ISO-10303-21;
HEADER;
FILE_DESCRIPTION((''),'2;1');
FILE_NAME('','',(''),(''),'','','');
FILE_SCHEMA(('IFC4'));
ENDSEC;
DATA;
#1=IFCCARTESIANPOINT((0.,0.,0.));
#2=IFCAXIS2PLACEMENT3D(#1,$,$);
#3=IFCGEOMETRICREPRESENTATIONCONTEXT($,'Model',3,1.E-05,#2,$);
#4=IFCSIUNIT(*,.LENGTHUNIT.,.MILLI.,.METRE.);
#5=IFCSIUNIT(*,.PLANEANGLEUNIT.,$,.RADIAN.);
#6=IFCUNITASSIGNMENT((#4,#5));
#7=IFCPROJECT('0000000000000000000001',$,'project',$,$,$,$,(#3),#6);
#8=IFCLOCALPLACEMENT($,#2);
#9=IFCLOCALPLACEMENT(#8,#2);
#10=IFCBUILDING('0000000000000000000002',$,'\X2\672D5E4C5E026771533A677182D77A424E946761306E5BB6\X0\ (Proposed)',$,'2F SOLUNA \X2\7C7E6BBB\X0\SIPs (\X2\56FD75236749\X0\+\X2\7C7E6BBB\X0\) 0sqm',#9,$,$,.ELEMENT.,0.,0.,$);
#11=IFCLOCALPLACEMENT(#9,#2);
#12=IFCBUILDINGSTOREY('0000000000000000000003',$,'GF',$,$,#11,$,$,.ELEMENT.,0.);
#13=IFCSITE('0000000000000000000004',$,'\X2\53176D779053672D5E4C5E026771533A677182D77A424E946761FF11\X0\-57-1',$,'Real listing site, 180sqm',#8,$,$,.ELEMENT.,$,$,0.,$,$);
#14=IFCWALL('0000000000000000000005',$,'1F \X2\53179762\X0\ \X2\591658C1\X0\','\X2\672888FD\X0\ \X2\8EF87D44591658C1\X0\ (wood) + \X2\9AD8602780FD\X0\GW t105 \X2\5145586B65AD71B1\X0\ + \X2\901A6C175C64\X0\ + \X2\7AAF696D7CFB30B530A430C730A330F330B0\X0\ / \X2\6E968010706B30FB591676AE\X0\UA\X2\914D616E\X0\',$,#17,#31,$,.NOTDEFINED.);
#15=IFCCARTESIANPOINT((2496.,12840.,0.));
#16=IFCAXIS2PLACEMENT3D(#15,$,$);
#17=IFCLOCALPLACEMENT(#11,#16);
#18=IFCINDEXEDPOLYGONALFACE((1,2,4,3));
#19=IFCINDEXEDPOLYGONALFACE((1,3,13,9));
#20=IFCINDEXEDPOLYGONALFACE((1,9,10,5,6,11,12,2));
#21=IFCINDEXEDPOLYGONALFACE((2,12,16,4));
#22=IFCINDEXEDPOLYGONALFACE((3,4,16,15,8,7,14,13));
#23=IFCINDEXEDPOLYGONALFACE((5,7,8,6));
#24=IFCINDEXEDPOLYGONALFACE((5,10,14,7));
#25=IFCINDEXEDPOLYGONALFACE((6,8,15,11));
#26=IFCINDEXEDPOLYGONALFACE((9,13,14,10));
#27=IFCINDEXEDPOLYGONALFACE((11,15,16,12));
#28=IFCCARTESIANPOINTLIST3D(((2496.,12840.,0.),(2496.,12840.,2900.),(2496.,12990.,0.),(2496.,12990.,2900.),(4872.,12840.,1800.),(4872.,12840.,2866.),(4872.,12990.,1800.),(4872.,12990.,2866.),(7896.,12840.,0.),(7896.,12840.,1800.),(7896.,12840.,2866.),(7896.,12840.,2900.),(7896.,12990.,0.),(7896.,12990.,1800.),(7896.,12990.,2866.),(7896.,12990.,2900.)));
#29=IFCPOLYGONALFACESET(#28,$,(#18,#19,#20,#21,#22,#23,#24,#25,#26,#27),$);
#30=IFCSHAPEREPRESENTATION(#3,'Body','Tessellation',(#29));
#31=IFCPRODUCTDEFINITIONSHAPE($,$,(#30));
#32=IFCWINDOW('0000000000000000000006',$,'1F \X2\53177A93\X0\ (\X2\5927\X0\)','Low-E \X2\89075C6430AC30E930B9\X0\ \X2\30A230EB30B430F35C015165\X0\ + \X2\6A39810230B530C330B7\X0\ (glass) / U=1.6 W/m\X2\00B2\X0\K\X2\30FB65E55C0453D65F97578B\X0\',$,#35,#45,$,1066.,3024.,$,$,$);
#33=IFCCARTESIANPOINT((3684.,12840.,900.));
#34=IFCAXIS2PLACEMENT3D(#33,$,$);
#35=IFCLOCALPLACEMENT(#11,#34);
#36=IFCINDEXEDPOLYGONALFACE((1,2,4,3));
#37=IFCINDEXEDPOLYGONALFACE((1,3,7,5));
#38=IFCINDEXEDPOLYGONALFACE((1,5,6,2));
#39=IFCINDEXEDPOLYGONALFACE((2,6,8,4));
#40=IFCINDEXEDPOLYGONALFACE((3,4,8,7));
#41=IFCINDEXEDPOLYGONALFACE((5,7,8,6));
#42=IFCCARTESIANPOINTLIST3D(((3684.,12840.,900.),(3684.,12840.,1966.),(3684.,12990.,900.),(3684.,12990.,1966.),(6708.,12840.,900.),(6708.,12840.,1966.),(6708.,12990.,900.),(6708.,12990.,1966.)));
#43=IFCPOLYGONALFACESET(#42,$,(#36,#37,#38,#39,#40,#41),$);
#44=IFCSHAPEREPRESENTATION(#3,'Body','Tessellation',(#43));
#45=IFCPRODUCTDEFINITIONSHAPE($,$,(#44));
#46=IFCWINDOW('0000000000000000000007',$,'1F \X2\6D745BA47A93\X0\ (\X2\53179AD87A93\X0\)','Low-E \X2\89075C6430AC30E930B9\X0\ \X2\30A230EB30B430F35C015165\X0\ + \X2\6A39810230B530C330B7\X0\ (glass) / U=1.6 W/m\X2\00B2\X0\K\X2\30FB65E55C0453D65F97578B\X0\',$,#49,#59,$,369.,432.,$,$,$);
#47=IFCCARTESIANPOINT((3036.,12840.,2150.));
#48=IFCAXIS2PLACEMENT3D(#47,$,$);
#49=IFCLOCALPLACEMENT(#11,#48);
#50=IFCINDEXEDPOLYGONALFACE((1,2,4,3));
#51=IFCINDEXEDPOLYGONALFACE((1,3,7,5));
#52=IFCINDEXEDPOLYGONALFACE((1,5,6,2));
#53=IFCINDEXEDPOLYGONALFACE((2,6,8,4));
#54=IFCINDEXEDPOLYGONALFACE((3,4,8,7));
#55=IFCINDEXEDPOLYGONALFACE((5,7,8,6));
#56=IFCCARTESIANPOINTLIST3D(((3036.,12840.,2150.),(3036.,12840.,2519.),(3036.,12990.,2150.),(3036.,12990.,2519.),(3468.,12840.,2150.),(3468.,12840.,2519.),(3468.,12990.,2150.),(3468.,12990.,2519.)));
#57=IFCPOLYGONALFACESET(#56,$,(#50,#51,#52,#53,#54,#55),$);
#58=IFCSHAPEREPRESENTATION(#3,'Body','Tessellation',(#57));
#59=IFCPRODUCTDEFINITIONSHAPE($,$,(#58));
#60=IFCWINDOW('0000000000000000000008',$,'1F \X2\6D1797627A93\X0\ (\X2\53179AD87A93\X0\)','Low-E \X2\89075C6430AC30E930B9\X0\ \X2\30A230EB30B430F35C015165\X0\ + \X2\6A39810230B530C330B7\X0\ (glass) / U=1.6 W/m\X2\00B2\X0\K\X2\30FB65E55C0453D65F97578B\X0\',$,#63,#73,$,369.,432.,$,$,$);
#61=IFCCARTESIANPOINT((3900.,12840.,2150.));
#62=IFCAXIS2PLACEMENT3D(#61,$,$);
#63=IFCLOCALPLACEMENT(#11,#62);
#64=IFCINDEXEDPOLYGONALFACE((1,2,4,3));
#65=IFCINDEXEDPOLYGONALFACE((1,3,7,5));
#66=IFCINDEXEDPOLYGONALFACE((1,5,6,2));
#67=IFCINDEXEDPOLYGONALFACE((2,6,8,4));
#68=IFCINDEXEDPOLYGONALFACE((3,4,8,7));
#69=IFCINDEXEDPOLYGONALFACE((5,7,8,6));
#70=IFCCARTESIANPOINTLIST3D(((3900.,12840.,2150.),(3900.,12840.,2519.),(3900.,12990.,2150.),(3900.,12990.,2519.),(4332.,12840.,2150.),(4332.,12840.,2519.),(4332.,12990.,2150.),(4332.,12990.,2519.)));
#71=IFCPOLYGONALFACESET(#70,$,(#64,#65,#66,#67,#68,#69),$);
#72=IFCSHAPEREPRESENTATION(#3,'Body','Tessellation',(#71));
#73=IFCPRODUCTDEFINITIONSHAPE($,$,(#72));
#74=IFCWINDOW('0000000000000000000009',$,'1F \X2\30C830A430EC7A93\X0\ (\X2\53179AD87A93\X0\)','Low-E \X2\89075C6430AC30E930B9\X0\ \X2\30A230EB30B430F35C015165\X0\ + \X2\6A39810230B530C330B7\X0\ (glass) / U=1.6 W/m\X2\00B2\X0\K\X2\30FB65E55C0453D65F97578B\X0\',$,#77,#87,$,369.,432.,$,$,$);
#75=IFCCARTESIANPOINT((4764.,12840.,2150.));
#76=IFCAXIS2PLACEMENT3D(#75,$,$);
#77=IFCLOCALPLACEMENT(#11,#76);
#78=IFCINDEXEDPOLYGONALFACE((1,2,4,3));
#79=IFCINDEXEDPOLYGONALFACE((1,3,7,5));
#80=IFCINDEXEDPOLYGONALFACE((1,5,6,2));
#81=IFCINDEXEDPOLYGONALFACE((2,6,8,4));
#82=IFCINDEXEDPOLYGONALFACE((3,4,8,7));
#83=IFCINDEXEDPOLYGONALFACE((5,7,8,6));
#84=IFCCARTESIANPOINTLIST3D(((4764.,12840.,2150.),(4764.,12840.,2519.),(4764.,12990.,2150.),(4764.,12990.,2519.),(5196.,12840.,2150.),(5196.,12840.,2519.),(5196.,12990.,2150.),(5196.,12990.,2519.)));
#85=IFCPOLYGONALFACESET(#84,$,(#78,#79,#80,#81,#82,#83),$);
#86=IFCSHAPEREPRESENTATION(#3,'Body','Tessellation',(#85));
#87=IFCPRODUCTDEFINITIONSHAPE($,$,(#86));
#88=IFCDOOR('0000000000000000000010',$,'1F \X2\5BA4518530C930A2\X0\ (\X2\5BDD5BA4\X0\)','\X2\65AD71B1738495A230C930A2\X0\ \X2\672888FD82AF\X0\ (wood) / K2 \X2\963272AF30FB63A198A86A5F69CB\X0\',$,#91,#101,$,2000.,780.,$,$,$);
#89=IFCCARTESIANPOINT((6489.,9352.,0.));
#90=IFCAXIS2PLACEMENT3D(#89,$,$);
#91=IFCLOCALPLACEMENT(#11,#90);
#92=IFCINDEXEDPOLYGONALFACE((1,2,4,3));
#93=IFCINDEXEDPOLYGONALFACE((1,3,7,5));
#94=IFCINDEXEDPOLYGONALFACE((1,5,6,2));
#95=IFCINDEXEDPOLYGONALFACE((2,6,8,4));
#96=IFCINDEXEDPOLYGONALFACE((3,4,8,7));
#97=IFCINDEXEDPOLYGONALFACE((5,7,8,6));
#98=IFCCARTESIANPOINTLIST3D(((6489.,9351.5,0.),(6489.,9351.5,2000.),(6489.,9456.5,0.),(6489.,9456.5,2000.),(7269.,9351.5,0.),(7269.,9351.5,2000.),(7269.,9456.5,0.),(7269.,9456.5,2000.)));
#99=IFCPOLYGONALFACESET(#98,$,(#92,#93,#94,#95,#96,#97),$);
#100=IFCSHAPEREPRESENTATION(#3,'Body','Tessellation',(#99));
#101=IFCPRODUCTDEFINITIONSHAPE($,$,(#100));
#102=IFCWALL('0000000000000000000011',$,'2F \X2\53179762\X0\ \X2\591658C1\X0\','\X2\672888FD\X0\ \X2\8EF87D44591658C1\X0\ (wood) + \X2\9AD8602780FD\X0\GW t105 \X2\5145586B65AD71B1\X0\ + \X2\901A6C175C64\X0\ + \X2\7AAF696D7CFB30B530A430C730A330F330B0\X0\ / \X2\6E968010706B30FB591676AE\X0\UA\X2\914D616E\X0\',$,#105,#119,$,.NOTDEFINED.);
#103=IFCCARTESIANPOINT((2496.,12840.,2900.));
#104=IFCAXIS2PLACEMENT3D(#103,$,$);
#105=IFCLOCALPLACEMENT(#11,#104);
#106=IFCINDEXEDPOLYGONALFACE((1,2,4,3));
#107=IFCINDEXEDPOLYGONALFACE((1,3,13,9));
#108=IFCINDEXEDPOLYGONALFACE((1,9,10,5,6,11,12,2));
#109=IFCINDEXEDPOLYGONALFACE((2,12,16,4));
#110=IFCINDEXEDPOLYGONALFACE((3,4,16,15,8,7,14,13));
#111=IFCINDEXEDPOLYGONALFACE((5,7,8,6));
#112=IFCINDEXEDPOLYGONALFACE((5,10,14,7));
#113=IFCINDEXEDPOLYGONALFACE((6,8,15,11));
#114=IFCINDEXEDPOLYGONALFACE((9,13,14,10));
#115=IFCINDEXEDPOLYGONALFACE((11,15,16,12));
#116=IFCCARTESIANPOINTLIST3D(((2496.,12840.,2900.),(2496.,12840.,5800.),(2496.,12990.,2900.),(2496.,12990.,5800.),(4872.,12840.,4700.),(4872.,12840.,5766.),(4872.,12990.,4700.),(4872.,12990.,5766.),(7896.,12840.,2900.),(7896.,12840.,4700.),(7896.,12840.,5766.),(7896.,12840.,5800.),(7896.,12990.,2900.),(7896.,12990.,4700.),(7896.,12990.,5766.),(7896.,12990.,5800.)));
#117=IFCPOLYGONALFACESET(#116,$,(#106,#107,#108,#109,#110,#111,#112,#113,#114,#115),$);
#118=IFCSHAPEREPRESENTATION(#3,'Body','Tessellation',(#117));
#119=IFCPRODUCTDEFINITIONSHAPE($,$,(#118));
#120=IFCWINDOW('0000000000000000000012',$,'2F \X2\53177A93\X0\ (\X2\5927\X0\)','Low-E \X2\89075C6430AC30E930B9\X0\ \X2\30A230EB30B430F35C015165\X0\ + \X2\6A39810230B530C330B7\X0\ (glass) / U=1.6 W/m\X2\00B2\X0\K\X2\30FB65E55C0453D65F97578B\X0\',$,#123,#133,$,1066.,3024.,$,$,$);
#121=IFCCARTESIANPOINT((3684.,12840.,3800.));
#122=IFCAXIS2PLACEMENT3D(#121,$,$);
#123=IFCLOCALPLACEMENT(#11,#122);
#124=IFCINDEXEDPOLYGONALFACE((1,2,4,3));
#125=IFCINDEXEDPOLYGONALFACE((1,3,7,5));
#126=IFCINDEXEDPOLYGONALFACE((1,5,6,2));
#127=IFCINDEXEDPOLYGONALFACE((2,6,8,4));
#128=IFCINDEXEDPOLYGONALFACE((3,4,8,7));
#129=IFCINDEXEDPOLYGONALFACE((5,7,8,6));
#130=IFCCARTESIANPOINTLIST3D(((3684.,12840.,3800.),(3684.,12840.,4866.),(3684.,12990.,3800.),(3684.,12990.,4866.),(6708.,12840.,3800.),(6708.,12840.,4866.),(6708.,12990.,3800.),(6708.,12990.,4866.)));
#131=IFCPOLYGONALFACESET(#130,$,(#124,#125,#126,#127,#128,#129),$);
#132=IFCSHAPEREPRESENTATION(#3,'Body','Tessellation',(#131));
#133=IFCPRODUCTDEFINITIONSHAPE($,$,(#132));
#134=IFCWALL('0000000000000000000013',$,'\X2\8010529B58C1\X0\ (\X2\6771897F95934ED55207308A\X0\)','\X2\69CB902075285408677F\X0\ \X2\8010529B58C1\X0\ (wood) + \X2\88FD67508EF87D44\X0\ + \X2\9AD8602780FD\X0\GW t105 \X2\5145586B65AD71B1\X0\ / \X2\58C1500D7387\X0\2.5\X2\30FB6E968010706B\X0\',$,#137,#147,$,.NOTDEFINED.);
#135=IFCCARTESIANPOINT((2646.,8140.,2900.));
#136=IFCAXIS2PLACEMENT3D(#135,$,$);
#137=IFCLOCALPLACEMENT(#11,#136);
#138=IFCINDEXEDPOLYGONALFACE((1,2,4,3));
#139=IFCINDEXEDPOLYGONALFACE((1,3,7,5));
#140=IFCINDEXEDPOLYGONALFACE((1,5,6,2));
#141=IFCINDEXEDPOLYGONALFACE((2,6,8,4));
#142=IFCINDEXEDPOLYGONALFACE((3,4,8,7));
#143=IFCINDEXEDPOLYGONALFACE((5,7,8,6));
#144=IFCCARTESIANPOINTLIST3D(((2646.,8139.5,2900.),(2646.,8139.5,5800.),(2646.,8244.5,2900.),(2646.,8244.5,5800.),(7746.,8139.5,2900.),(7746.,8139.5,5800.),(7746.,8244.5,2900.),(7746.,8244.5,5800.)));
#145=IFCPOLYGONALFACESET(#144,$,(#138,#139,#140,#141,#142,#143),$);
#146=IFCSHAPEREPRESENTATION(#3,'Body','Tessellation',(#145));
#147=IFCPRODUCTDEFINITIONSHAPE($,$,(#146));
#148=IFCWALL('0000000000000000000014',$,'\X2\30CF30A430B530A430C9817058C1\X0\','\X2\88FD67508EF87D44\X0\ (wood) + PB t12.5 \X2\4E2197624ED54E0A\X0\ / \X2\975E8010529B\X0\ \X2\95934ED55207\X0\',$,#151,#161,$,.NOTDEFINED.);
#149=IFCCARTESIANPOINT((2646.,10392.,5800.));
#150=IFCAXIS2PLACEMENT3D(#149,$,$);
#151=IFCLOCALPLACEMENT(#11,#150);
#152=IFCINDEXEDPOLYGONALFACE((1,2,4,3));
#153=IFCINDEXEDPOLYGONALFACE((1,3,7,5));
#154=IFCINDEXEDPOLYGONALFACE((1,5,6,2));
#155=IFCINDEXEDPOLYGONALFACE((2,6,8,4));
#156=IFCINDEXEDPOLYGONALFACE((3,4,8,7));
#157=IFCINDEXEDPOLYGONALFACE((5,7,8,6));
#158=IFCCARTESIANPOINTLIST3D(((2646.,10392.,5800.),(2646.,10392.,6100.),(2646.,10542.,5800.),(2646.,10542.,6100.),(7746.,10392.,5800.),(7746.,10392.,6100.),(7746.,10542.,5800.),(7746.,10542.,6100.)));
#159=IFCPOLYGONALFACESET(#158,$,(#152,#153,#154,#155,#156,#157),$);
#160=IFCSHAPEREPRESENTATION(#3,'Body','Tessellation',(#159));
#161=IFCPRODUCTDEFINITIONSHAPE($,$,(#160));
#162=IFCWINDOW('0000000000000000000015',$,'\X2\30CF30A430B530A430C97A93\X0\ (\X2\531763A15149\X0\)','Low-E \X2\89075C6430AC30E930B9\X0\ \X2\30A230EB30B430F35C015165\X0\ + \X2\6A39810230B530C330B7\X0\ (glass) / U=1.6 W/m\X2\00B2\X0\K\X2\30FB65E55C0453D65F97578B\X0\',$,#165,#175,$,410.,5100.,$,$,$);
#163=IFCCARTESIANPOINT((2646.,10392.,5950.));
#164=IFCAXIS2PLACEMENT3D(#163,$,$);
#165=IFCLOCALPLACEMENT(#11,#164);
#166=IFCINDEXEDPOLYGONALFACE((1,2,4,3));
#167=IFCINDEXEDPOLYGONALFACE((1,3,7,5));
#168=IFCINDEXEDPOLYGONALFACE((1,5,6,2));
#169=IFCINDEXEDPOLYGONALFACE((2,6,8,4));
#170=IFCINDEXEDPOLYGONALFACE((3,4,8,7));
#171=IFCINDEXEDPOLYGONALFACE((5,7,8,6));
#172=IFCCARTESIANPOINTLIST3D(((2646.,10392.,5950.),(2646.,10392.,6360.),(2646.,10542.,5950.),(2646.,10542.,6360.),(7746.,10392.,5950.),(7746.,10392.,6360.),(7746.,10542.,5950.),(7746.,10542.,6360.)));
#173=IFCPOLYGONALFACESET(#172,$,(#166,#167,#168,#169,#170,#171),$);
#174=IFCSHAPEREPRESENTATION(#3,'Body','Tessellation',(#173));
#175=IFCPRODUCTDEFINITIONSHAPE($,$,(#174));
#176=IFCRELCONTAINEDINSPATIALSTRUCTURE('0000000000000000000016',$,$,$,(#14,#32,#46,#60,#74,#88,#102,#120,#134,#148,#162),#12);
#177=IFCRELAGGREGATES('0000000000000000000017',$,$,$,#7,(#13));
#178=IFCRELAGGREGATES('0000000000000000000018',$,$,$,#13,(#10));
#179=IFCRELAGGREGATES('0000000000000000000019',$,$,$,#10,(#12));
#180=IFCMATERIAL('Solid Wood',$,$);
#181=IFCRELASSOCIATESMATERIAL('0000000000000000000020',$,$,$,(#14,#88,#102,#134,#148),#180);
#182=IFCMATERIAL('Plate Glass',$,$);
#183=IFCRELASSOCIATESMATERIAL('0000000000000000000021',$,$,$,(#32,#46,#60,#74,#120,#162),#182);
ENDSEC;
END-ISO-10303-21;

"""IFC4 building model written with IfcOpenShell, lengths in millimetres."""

from ifc_helpers import new_model, si_unit, frame, frame_2d, origin, place, context, project, spatial, rectangle, extrude, material, element, fill, save


model = new_model("IFC4")

# Units and contexts
model_context = context("Model", 3, precision=1e-05, world=origin())
ifc_project = project(units=[si_unit("LENGTHUNIT", "METRE", prefix="MILLI"), si_unit("PLANEANGLEUNIT", "RADIAN")], contexts=[model_context])

# Site, building, storey
site_placement = place(None, origin())
site = spatial("IfcSite", under=ifc_project, at=site_placement, Name="北海道札幌市東区東苗穂五条１-57-1", ObjectType="Real listing site, 180sqm", CompositionType="ELEMENT", RefElevation=0.0)
building_placement = place(site_placement, origin())
building = spatial("IfcBuilding", under=site, at=building_placement, Name="札幌市東区東苗穂五条の家 (Proposed)", ObjectType="2F SOLUNA 籾殻SIPs (国産杉+籾殻) 0sqm", CompositionType="ELEMENT", ElevationOfRefHeight=0.0, ElevationOfTerrain=0.0)
storey_placement = place(building_placement, origin())
storey = spatial("IfcBuildingStorey", under=building, at=storey_placement, Name="GF", CompositionType="ELEMENT", Elevation=0.0)

# Wall, openings, windows
ifc_material_1 = material(Name="Solid Wood")
wall_1_placement = place(storey_placement, frame((2496.0, 12840.0, 0.0)))
wall_1 = element("IfcWall", 1, at=wall_1_placement, inside=storey, material=ifc_material_1, Name="1F 北面 外壁", Description="木製 軸組外壁 (wood) + 高性能GW t105 充填断熱 + 通気層 + 窯業系サイディング / 準耐火・外皮UA配慮", PredefinedType="NOTDEFINED", context=model_context, shape_type="SweptSolid", body=[
    extrude(rectangle(XDim=5400.0, YDim=150.0, at=frame_2d((2700.0, 75.0))), frame((2496.0, 12840.0, 0.0)), (0.0, 0.0, 1.0), 2900.0),
])
opening_1_placement = place(storey_placement, frame((3684.0, 12840.0, 900.0)))
opening_1 = element("IfcOpeningElement", 2, at=opening_1_placement, cuts=wall_1, PredefinedType="NOTDEFINED", context=model_context, shape_type="SweptSolid", body=[
    extrude(rectangle(XDim=3024.0, YDim=150.0, at=frame_2d((1512.0, 75.0))), frame((3684.0, 12840.0, 900.0)), (0.0, 0.0, 1.0), 1066.0),
])
opening_2_placement = place(storey_placement, frame((3036.0, 12840.0, 2150.0)))
opening_2 = element("IfcOpeningElement", 3, at=opening_2_placement, cuts=wall_1, PredefinedType="NOTDEFINED", context=model_context, shape_type="SweptSolid", body=[
    extrude(rectangle(XDim=432.0, YDim=150.0, at=frame_2d((216.0, 75.0))), frame((3036.0, 12840.0, 2150.0)), (0.0, 0.0, 1.0), 369.0),
])
opening_3_placement = place(storey_placement, frame((3900.0, 12840.0, 2150.0)))
opening_3 = element("IfcOpeningElement", 4, at=opening_3_placement, cuts=wall_1, PredefinedType="NOTDEFINED", context=model_context, shape_type="SweptSolid", body=[
    extrude(rectangle(XDim=432.0, YDim=150.0, at=frame_2d((216.0, 75.0))), frame((3900.0, 12840.0, 2150.0)), (0.0, 0.0, 1.0), 369.0),
])
opening_4_placement = place(storey_placement, frame((4764.0, 12840.0, 2150.0)))
opening_4 = element("IfcOpeningElement", 5, at=opening_4_placement, cuts=wall_1, PredefinedType="NOTDEFINED", context=model_context, shape_type="SweptSolid", body=[
    extrude(rectangle(XDim=432.0, YDim=150.0, at=frame_2d((216.0, 75.0))), frame((4764.0, 12840.0, 2150.0)), (0.0, 0.0, 1.0), 369.0),
])
ifc_material_2 = material(Name="Plate Glass")
window_1_placement = place(storey_placement, frame((3684.0, 12840.0, 900.0)))
window_1 = element("IfcWindow", 6, at=window_1_placement, inside=storey, material=ifc_material_2, Name="1F 北窓 (大)", Description="Low-E 複層ガラス アルゴン封入 + 樹脂サッシ (glass) / U=1.6 W/m²K・日射取得型", OverallHeight=1066.0, OverallWidth=3024.0, context=model_context, shape_type="SweptSolid", body=[
    extrude(rectangle(XDim=3024.0, YDim=150.0, at=frame_2d((1512.0, 75.0))), frame((3684.0, 12840.0, 900.0)), (0.0, 0.0, 1.0), 1066.0),
])
fill(opening_1, window_1)
window_2_placement = place(storey_placement, frame((3036.0, 12840.0, 2150.0)))
window_2 = element("IfcWindow", 7, at=window_2_placement, inside=storey, material=ifc_material_2, Name="1F 浴室窓 (北高窓)", Description="Low-E 複層ガラス アルゴン封入 + 樹脂サッシ (glass) / U=1.6 W/m²K・日射取得型", OverallHeight=369.0, OverallWidth=432.0, context=model_context, shape_type="SweptSolid", body=[
    extrude(rectangle(XDim=432.0, YDim=150.0, at=frame_2d((216.0, 75.0))), frame((3036.0, 12840.0, 2150.0)), (0.0, 0.0, 1.0), 369.0),
])
fill(opening_2, window_2)
window_3_placement = place(storey_placement, frame((3900.0, 12840.0, 2150.0)))
window_3 = element("IfcWindow", 8, at=window_3_placement, inside=storey, material=ifc_material_2, Name="1F 洗面窓 (北高窓)", Description="Low-E 複層ガラス アルゴン封入 + 樹脂サッシ (glass) / U=1.6 W/m²K・日射取得型", OverallHeight=369.0, OverallWidth=432.0, context=model_context, shape_type="SweptSolid", body=[
    extrude(rectangle(XDim=432.0, YDim=150.0, at=frame_2d((216.0, 75.0))), frame((3900.0, 12840.0, 2150.0)), (0.0, 0.0, 1.0), 369.0),
])
fill(opening_3, window_3)
window_4_placement = place(storey_placement, frame((4764.0, 12840.0, 2150.0)))
window_4 = element("IfcWindow", 9, at=window_4_placement, inside=storey, material=ifc_material_2, Name="1F トイレ窓 (北高窓)", Description="Low-E 複層ガラス アルゴン封入 + 樹脂サッシ (glass) / U=1.6 W/m²K・日射取得型", OverallHeight=369.0, OverallWidth=432.0, context=model_context, shape_type="SweptSolid", body=[
    extrude(rectangle(XDim=432.0, YDim=150.0, at=frame_2d((216.0, 75.0))), frame((4764.0, 12840.0, 2150.0)), (0.0, 0.0, 1.0), 369.0),
])
fill(opening_4, window_4)

# Door
door_1_placement = place(storey_placement, frame((6489.0, 9352.0, 0.0)))
element("IfcDoor", 10, at=door_1_placement, inside=storey, material=ifc_material_1, Name="1F 室内ドア (寝室)", Description="断熱玄関ドア 木製芯 (wood) / K2 防犯・採風機構", OverallHeight=2000.0, OverallWidth=780.0, context=model_context, shape_type="SweptSolid", body=[
    extrude(rectangle(XDim=780.0, YDim=105.0, at=frame_2d((390.0, 52.0))), frame((6489.0, 9352.0, 0.0)), (0.0, 0.0, 1.0), 2000.0),
])

# Wall, opening, window
wall_2_placement = place(storey_placement, frame((2496.0, 12840.0, 2900.0)))
wall_2 = element("IfcWall", 11, at=wall_2_placement, inside=storey, material=ifc_material_1, Name="2F 北面 外壁", Description="木製 軸組外壁 (wood) + 高性能GW t105 充填断熱 + 通気層 + 窯業系サイディング / 準耐火・外皮UA配慮", PredefinedType="NOTDEFINED", context=model_context, shape_type="SweptSolid", body=[
    extrude(rectangle(XDim=5400.0, YDim=150.0, at=frame_2d((2700.0, 75.0))), frame((2496.0, 12840.0, 2900.0)), (0.0, 0.0, 1.0), 2900.0),
])
opening_5_placement = place(storey_placement, frame((3684.0, 12840.0, 3800.0)))
opening_5 = element("IfcOpeningElement", 12, at=opening_5_placement, cuts=wall_2, PredefinedType="NOTDEFINED", context=model_context, shape_type="SweptSolid", body=[
    extrude(rectangle(XDim=3024.0, YDim=150.0, at=frame_2d((1512.0, 75.0))), frame((3684.0, 12840.0, 3800.0)), (0.0, 0.0, 1.0), 1066.0),
])
window_5_placement = place(storey_placement, frame((3684.0, 12840.0, 3800.0)))
window_5 = element("IfcWindow", 13, at=window_5_placement, inside=storey, material=ifc_material_2, Name="2F 北窓 (大)", Description="Low-E 複層ガラス アルゴン封入 + 樹脂サッシ (glass) / U=1.6 W/m²K・日射取得型", OverallHeight=1066.0, OverallWidth=3024.0, context=model_context, shape_type="SweptSolid", body=[
    extrude(rectangle(XDim=3024.0, YDim=150.0, at=frame_2d((1512.0, 75.0))), frame((3684.0, 12840.0, 3800.0)), (0.0, 0.0, 1.0), 1066.0),
])
fill(opening_5, window_5)

# Wall
wall_3_placement = place(storey_placement, frame((2646.0, 8140.0, 2900.0)))
element("IfcWall", 14, at=wall_3_placement, inside=storey, material=ifc_material_1, Name="耐力壁 (東西間仕切り)", Description="構造用合板 耐力壁 (wood) + 製材軸組 + 高性能GW t105 充填断熱 / 壁倍率2.5・準耐火", PredefinedType="NOTDEFINED", context=model_context, shape_type="SweptSolid", body=[
    extrude(rectangle(XDim=5100.0, YDim=105.0, at=frame_2d((2550.0, 52.0))), frame((2646.0, 8140.0, 2900.0)), (0.0, 0.0, 1.0), 2900.0),
])

# Wall, opening, window
wall_4_placement = place(storey_placement, frame((2646.0, 10392.0, 5800.0)))
wall_4 = element("IfcWall", 15, at=wall_4_placement, inside=storey, material=ifc_material_1, Name="ハイサイド腰壁", Description="製材軸組 (wood) + PB t12.5 両面仕上 / 非耐力 間仕切", PredefinedType="NOTDEFINED", context=model_context, shape_type="SweptSolid", body=[
    extrude(rectangle(XDim=5100.0, YDim=150.0, at=frame_2d((2550.0, 75.0))), frame((2646.0, 10392.0, 5800.0)), (0.0, 0.0, 1.0), 700.0),
])
opening_6_placement = place(storey_placement, frame((2646.0, 10392.0, 5950.0)))
opening_6 = element("IfcOpeningElement", 16, at=opening_6_placement, cuts=wall_4, PredefinedType="NOTDEFINED", context=model_context, shape_type="SweptSolid", body=[
    extrude(rectangle(XDim=5100.0, YDim=150.0, at=frame_2d((2550.0, 75.0))), frame((2646.0, 10392.0, 5950.0)), (0.0, 0.0, 1.0), 410.0),
])
window_6_placement = place(storey_placement, frame((2646.0, 10392.0, 5950.0)))
window_6 = element("IfcWindow", 17, at=window_6_placement, inside=storey, material=ifc_material_2, Name="ハイサイド窓 (北採光)", Description="Low-E 複層ガラス アルゴン封入 + 樹脂サッシ (glass) / U=1.6 W/m²K・日射取得型", OverallHeight=410.0, OverallWidth=5100.0, context=model_context, shape_type="SweptSolid", body=[
    extrude(rectangle(XDim=5100.0, YDim=150.0, at=frame_2d((2550.0, 75.0))), frame((2646.0, 10392.0, 5950.0)), (0.0, 0.0, 1.0), 410.0),
])
fill(opening_6, window_6)

save(model, "model.ifc")
